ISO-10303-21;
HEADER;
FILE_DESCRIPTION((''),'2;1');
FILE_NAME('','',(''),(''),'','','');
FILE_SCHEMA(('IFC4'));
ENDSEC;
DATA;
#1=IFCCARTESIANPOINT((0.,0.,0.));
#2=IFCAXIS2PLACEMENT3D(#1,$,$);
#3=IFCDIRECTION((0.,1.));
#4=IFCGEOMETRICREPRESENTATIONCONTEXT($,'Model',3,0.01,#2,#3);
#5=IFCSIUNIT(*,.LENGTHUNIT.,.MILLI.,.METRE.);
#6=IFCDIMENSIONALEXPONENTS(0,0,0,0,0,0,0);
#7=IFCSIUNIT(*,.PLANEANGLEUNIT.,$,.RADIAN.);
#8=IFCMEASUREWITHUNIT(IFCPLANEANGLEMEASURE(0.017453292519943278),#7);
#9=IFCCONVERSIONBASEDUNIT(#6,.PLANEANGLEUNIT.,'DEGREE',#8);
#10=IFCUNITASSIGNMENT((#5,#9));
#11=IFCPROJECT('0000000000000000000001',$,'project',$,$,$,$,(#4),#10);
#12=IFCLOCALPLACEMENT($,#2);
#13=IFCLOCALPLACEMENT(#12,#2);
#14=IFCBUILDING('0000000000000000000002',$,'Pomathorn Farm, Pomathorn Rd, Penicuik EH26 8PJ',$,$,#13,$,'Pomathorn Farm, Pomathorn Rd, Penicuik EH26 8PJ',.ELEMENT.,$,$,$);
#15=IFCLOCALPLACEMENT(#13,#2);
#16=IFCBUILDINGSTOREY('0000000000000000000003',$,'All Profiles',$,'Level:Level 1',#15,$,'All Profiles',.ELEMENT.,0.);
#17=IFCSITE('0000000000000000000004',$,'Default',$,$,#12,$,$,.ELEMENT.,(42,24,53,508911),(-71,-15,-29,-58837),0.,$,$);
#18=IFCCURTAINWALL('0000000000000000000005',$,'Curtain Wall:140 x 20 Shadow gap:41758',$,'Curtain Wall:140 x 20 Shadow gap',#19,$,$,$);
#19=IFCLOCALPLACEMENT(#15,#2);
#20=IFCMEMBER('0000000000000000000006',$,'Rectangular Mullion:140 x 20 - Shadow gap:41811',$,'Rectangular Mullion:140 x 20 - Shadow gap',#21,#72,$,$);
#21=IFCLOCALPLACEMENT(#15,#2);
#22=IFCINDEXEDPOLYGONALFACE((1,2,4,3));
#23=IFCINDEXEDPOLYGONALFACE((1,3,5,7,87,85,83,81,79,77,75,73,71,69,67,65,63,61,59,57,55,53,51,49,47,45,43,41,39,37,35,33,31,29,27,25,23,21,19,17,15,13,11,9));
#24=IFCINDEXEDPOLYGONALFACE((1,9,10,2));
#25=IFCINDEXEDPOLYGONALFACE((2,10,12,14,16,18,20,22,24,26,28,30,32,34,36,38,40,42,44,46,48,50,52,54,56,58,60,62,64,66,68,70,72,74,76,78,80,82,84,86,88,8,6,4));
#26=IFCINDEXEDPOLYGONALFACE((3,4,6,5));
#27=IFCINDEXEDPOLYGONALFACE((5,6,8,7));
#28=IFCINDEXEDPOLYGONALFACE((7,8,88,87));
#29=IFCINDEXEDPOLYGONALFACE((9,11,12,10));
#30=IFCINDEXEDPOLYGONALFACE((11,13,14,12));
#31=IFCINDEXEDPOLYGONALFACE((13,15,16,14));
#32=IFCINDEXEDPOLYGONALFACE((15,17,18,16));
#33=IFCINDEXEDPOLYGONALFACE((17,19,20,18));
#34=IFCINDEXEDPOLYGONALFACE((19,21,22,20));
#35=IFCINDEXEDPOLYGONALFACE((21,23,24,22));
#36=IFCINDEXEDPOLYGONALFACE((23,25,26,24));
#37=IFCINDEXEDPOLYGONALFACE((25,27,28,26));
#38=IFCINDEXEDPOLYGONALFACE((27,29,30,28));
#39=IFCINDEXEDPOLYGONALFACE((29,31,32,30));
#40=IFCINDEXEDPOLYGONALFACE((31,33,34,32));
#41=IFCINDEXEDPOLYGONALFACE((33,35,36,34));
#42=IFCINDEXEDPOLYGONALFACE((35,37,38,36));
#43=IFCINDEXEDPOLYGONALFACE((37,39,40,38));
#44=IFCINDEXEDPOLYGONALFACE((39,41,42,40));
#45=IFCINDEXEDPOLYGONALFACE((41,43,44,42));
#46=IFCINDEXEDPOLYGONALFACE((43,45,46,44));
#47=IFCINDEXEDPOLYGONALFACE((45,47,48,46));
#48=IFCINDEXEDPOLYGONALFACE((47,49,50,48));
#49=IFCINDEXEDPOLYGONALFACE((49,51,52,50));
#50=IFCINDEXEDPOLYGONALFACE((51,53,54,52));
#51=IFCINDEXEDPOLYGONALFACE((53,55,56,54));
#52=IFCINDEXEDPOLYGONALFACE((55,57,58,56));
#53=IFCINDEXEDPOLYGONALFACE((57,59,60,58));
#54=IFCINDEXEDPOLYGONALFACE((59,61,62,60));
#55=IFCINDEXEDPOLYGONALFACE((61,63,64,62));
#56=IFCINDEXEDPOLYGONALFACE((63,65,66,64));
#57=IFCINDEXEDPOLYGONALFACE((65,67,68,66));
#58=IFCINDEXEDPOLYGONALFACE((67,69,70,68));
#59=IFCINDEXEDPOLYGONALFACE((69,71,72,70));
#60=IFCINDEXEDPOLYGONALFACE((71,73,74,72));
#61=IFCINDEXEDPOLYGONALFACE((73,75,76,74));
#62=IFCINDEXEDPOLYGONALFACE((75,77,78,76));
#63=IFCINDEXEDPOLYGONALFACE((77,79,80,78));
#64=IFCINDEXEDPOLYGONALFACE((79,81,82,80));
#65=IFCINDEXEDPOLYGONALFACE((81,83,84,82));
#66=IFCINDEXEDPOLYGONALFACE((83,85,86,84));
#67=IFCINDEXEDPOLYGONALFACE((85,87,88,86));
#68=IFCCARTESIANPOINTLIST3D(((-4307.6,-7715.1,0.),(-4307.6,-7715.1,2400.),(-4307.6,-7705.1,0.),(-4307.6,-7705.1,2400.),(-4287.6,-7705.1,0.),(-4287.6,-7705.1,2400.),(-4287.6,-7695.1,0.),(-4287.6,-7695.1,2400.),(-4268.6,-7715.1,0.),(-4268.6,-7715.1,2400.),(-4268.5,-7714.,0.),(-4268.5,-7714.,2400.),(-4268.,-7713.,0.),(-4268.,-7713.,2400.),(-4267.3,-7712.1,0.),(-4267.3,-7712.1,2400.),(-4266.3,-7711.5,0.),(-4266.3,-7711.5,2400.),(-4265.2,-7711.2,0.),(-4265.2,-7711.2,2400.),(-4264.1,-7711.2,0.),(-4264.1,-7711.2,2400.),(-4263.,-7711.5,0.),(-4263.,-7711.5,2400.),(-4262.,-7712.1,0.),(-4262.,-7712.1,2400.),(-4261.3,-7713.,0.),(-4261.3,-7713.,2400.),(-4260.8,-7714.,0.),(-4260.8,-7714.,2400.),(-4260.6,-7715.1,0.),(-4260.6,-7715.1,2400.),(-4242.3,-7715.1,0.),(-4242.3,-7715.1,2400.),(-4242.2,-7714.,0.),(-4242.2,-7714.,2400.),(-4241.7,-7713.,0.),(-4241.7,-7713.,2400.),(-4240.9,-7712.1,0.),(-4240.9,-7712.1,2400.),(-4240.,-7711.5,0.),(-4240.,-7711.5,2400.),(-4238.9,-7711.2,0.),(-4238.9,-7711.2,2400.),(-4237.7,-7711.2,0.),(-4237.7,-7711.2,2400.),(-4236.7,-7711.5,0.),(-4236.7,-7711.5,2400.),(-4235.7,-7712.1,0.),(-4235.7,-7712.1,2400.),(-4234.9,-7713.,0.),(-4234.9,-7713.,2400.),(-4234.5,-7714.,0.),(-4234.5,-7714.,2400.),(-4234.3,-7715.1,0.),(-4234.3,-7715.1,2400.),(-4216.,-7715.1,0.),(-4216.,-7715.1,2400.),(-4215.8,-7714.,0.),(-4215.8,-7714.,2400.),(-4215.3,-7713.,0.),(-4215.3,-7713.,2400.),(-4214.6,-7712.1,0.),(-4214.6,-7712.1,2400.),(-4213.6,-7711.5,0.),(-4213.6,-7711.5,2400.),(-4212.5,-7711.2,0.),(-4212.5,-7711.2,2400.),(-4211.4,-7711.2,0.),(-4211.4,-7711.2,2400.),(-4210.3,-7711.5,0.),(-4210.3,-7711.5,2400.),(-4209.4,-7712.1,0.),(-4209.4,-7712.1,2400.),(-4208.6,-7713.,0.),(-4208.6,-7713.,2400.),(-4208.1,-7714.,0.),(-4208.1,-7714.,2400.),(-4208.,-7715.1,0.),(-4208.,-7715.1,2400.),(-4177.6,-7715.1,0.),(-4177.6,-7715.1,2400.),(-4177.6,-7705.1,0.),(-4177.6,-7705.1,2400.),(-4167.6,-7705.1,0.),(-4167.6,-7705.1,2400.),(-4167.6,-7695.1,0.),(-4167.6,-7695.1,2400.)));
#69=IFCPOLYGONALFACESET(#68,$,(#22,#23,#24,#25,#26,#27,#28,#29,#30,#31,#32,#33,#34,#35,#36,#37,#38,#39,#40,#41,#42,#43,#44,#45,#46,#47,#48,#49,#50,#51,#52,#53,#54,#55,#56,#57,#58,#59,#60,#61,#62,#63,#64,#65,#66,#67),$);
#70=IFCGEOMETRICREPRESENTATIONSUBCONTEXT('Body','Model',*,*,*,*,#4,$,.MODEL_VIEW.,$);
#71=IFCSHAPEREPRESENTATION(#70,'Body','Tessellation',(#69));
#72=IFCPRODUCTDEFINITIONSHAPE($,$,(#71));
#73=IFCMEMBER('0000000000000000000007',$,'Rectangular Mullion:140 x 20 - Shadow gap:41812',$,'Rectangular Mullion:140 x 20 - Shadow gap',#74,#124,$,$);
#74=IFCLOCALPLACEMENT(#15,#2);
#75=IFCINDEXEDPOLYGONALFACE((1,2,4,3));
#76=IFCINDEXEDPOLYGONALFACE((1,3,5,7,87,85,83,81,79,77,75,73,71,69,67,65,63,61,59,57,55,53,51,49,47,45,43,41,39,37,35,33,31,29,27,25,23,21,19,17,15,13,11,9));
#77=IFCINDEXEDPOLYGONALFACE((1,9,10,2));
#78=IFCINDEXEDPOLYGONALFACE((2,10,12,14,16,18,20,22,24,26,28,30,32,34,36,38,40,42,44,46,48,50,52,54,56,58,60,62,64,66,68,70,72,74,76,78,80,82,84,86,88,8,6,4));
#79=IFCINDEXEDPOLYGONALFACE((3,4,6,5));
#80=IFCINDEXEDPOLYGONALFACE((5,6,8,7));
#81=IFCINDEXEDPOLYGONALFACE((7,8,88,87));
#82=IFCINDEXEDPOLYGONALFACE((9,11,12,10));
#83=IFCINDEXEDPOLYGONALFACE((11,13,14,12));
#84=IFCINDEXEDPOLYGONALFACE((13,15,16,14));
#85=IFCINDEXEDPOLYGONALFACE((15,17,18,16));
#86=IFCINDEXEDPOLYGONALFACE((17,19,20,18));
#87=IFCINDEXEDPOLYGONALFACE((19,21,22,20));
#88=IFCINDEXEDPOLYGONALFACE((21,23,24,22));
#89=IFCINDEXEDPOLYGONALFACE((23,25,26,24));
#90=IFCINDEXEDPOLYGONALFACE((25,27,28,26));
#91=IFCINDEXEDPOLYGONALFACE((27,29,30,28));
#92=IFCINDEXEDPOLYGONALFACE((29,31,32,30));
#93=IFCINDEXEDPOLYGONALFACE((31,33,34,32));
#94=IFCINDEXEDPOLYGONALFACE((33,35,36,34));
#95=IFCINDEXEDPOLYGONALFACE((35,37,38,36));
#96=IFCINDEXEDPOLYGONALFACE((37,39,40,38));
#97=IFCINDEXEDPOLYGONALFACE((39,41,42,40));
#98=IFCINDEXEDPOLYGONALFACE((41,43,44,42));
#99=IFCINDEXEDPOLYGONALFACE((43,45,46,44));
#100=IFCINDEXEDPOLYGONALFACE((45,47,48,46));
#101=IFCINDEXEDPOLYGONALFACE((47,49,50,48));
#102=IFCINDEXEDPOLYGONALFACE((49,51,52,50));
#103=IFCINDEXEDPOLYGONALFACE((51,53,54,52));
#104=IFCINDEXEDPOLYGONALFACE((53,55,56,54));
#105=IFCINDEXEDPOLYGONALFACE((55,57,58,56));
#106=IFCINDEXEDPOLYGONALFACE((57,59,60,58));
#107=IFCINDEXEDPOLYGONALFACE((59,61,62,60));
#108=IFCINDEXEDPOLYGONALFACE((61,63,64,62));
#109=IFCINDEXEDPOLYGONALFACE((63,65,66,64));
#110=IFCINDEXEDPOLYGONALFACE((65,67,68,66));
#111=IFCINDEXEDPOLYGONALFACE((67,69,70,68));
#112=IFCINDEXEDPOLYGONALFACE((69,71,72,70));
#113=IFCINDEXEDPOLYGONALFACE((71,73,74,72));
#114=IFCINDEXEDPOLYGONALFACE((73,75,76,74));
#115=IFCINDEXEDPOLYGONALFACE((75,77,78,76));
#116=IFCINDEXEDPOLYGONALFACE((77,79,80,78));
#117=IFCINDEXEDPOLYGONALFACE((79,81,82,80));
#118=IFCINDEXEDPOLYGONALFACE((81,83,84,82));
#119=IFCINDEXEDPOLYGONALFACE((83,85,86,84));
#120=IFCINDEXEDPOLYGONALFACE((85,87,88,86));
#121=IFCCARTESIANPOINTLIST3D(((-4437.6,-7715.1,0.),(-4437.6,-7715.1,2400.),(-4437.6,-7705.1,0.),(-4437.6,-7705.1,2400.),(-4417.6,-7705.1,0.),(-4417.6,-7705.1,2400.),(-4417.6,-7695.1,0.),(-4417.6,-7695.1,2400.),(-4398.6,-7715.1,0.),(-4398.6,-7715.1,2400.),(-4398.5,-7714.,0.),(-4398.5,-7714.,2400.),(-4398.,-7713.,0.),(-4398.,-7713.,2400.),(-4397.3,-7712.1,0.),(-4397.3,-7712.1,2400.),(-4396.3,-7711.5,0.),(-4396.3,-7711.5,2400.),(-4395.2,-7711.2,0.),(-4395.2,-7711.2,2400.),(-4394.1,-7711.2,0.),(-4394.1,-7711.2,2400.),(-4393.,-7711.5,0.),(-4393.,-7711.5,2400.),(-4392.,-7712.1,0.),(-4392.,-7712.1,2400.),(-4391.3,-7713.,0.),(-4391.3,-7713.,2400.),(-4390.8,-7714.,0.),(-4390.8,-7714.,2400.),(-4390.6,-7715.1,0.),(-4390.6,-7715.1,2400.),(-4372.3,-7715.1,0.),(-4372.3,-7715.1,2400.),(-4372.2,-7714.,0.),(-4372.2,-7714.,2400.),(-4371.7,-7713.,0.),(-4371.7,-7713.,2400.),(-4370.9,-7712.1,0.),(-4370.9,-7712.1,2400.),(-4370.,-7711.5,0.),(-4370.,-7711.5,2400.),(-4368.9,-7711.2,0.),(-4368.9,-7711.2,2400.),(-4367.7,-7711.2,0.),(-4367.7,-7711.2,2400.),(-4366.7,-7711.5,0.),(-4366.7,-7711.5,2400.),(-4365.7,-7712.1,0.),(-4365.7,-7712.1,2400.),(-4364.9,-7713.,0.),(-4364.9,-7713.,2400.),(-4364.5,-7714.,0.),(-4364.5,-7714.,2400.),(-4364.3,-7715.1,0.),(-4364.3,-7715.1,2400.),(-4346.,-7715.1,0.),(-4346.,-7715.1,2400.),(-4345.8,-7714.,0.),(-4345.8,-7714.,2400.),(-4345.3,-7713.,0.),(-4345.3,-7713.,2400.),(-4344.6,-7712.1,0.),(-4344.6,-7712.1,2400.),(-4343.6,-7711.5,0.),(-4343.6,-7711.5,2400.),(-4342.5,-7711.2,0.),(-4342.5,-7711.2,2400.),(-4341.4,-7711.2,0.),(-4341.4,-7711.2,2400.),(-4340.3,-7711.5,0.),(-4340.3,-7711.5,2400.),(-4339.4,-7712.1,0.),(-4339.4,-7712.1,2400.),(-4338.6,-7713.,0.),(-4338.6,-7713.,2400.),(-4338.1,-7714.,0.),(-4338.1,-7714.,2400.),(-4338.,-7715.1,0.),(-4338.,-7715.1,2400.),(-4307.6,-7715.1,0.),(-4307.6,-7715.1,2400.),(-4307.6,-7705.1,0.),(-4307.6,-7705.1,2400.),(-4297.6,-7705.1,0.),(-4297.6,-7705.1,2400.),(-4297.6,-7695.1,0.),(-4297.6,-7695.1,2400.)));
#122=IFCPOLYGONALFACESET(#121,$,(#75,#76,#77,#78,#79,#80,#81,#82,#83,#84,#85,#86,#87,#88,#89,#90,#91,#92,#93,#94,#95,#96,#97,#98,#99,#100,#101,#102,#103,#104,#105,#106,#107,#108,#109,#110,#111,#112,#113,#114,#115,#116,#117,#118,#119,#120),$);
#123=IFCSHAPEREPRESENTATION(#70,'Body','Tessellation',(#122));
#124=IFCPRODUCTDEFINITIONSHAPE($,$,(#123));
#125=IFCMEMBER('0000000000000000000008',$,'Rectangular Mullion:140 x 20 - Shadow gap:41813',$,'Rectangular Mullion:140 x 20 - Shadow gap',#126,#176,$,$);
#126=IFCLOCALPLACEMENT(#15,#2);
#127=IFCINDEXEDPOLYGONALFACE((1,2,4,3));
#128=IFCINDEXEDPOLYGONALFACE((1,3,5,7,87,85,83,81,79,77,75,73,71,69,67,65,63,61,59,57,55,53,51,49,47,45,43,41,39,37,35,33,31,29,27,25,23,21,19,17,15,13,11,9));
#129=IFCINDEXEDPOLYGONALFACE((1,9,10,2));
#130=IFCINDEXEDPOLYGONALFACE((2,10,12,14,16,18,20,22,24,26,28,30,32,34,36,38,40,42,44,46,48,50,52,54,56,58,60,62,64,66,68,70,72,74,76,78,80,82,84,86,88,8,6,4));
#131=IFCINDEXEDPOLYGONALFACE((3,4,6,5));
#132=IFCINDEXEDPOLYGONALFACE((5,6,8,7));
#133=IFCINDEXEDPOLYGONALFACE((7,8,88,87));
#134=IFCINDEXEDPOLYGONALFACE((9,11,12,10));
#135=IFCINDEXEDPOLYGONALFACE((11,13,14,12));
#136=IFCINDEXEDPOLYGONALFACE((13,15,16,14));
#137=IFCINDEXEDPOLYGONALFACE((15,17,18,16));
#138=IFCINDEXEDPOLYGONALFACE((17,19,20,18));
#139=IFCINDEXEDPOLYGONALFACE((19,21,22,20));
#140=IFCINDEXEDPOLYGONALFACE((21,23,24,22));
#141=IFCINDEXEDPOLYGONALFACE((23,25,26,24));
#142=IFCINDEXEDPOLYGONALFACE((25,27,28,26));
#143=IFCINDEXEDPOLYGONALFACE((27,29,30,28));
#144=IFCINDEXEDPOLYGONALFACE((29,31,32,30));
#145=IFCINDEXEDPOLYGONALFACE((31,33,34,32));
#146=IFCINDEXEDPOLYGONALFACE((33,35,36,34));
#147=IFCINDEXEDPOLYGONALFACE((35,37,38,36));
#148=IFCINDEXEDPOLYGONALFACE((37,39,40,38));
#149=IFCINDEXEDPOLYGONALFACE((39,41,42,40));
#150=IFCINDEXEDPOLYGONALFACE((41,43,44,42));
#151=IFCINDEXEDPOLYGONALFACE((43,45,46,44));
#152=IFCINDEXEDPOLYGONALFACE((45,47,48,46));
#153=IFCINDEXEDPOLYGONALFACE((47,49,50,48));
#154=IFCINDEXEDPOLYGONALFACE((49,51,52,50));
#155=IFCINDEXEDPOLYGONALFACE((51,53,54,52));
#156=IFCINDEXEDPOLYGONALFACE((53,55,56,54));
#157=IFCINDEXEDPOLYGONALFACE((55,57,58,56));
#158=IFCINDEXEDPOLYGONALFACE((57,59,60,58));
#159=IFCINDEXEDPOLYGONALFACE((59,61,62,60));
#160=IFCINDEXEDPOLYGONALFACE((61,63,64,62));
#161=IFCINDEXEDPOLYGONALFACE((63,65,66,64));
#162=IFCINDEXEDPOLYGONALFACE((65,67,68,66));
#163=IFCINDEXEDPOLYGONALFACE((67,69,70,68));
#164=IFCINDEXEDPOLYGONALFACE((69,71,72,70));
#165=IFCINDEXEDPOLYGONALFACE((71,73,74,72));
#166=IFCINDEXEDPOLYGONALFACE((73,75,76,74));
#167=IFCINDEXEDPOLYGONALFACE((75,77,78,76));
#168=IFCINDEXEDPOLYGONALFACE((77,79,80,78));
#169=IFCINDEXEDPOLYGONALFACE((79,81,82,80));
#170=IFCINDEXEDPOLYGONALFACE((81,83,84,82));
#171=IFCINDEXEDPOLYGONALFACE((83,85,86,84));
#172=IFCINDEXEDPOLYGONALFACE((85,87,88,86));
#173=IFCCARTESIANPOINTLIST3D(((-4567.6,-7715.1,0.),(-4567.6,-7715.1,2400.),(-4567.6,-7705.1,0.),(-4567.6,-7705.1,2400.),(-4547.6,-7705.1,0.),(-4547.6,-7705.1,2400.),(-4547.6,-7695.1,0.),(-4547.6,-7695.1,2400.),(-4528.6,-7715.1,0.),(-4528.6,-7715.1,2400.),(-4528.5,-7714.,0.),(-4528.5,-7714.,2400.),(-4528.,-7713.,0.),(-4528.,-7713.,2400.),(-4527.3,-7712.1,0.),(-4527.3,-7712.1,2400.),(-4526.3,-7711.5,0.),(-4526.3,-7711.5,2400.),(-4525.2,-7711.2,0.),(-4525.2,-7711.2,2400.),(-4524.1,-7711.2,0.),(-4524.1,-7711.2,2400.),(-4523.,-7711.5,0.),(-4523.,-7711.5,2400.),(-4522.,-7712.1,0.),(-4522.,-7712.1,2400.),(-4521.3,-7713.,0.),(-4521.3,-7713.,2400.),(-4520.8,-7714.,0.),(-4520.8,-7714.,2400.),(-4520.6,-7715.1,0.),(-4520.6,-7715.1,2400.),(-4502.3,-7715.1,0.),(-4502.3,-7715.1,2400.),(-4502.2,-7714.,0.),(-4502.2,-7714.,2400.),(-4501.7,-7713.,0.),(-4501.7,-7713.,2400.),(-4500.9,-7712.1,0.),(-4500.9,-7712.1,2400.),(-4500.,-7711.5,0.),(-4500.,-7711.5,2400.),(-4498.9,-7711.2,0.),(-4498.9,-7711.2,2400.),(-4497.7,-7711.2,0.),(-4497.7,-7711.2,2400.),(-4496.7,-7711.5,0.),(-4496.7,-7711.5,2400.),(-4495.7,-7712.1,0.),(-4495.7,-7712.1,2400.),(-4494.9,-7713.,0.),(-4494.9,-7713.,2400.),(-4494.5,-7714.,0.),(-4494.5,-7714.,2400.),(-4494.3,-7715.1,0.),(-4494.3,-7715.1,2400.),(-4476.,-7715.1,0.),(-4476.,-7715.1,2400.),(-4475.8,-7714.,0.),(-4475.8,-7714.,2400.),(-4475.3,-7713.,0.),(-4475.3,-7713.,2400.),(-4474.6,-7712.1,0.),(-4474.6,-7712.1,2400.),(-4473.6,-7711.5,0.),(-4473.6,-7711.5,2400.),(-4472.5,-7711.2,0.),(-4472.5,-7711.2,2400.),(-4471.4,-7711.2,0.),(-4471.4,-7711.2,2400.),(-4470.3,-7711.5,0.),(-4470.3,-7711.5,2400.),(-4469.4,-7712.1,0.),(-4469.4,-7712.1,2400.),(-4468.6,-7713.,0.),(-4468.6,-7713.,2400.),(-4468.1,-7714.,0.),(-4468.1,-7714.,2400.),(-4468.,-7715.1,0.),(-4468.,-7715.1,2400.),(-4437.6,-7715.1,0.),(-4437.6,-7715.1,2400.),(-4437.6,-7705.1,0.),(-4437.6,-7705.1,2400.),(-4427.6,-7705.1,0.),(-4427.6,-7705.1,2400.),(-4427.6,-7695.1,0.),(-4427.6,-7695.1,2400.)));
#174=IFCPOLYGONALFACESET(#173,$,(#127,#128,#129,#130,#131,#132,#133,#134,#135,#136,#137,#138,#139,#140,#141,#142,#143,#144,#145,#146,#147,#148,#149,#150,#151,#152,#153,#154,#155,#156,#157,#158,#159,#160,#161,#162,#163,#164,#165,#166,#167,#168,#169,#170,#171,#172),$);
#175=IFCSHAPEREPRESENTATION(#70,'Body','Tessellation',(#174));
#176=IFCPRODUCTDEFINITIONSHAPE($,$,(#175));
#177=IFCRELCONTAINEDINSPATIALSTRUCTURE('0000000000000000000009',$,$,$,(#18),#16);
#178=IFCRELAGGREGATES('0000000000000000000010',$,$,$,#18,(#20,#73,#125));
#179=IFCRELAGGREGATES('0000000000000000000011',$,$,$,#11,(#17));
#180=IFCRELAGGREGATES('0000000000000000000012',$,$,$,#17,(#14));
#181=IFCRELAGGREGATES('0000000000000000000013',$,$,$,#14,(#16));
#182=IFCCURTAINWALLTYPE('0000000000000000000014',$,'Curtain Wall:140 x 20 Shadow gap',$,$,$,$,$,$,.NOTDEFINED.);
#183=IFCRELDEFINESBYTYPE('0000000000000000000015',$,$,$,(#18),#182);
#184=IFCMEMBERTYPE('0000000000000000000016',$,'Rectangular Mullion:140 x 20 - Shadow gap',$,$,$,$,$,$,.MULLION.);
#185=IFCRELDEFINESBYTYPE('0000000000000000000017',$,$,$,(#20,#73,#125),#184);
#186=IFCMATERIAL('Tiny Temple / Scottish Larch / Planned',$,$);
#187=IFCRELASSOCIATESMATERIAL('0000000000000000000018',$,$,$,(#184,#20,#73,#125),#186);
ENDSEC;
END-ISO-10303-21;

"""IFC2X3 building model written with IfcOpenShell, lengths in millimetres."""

from ifc_helpers import new_model, entity, si_unit, converted_unit, direction, frame, frame_2d, origin, place, context, subcontext, project, spatial, polyline, circle_curve, parameter, trimmed, segment, composite_curve, outline, extrude, source, transform, mapped, material, type_object, type_shapes, element, aggregate, save


model = new_model("IFC2X3")

# Units and contexts
model_context = context("Model", 3, precision=0.01, world=origin(), true_north=direction((0.0, 1.0)))
body_context = subcontext(model_context, "Body", "Model", "MODEL_VIEW")
ifc_project = project(units=[si_unit("LENGTHUNIT", "METRE", prefix="MILLI"), converted_unit("PLANEANGLEUNIT", "DEGREE", entity("IfcPlaneAngleMeasure", 0.017453292519943278), si_unit("PLANEANGLEUNIT", "RADIAN"), dimensions=[0, 0, 0, 0, 0, 0, 0])], contexts=[model_context])

# Site, building, storey
site_placement = place(None, origin())
site = spatial("IfcSite", under=ifc_project, at=site_placement, Name="Default", CompositionType="ELEMENT", RefLatitude=(42, 24, 53, 508911), RefLongitude=(-71, -15, -29, -58837), RefElevation=0.0)
building_placement = place(site_placement, origin())
building = spatial("IfcBuilding", under=site, at=building_placement, Name="Pomathorn Farm, Pomathorn Rd, Penicuik EH26 8PJ", LongName="Pomathorn Farm, Pomathorn Rd, Penicuik EH26 8PJ", CompositionType="ELEMENT")
storey_placement = place(building_placement, origin())
storey = spatial("IfcBuildingStorey", under=building, at=storey_placement, Name="All Profiles", ObjectType="Level:Level 1", LongName="All Profiles", CompositionType="ELEMENT", Elevation=0.0)

# Curtain wall, members
ifc_material = material(Name="Tiny Temple / Scottish Larch / Planned")
curtain_wall_type_1 = type_object("IfcCurtainWallType", Name="Curtain Wall:140 x 20 Shadow gap", PredefinedType="NOTDEFINED")
curtain_wall_1_placement = place(storey_placement, origin())
curtain_wall_1 = element("IfcCurtainWall", 1, at=curtain_wall_1_placement, inside=storey, type_object=curtain_wall_type_1, Name="Curtain Wall:140 x 20 Shadow gap:41758", ObjectType="Curtain Wall:140 x 20 Shadow gap")
member_type_1 = type_object("IfcMemberType", Name="Rectangular Mullion:140 x 20 - Shadow gap", PredefinedType="MULLION", material=ifc_material)
shared_shape_1 = source(origin(), body_context, "Body", "SweptSolid", [
    extrude(outline(composite_curve([segment(polyline([(28.5, -5.7), (58.9, -5.7)]), True, "CONTINUOUS"), segment(polyline([(58.9, -5.7), (58.9, 4.3)]), True, "CONTINUOUS"), segment(polyline([(58.9, 4.3), (68.9, 4.3)]), True, "CONTINUOUS"), segment(polyline([(68.9, 4.3), (68.9, 14.3)]), True, "CONTINUOUS"), segment(polyline([(68.9, 14.3), (-51.1, 14.3)]), True, "CONTINUOUS"), segment(polyline([(-51.1, 14.3), (-51.1, 4.3)]), True, "CONTINUOUS"), segment(polyline([(-51.1, 4.3), (-71.1, 4.3)]), True, "CONTINUOUS"), segment(polyline([(-71.1, 4.3), (-71.1, -5.7)]), True, "CONTINUOUS"), segment(polyline([(-71.1, -5.7), (-32.1, -5.7)]), True, "CONTINUOUS"), segment(trimmed(circle_curve(frame_2d((-28.1, -5.7), x_axis=(1.0, 0.0)), 4.0), [parameter(360.0)], [parameter(180.0)], True, "PARAMETER"), False, "CONTINUOUS"), segment(polyline([(-24.1, -5.7), (-5.8, -5.7)]), True, "CONTINUOUS"), segment(trimmed(circle_curve(frame_2d((-1.8, -5.7), x_axis=(1.0, 0.0)), 4.0), [parameter(360.0)], [parameter(180.0)], True, "PARAMETER"), False, "CONTINUOUS"), segment(polyline([(2.2, -5.7), (20.5, -5.7)]), True, "CONTINUOUS"), segment(trimmed(circle_curve(frame_2d((24.5, -5.7), x_axis=(1.0, 0.0)), 4.0), [parameter(360.0)], [parameter(180.0)], True, "PARAMETER"), False, "CONTINUOUS")], self_intersect=False)), frame((-68.9, -5.7, -2400.0), z_axis=(0.0, 0.0, -1.0), x_axis=(1.0, 0.0, 0.0)), (0.0, 0.0, -1.0), 2400.0),
])
type_shapes(member_type_1, [shared_shape_1])
member_1_placement = place(curtain_wall_1_placement, frame((-4167.6, -7715.1, 0.0), z_axis=(0.0, 0.0, -1.0), x_axis=(1.0, 0.0, 0.0)))
member_1 = element("IfcMember", 2, at=member_1_placement, type_object=member_type_1, material=ifc_material, Name="Rectangular Mullion:140 x 20 - Shadow gap:41811", ObjectType="Rectangular Mullion:140 x 20 - Shadow gap", context=body_context, shape_type="MappedRepresentation", body=[
    mapped(shared_shape_1, transform((0.0, 0.0, 0.0), scale=1.0)),
])
member_2_placement = place(curtain_wall_1_placement, frame((-4297.6, -7715.1, 0.0), z_axis=(0.0, 0.0, -1.0), x_axis=(1.0, 0.0, 0.0)))
member_2 = element("IfcMember", 3, at=member_2_placement, type_object=member_type_1, material=ifc_material, Name="Rectangular Mullion:140 x 20 - Shadow gap:41812", ObjectType="Rectangular Mullion:140 x 20 - Shadow gap", context=body_context, shape_type="MappedRepresentation", body=[
    mapped(shared_shape_1, transform((0.0, 0.0, 0.0), scale=1.0)),
])
member_3_placement = place(curtain_wall_1_placement, frame((-4427.6, -7715.1, 0.0), z_axis=(0.0, 0.0, -1.0), x_axis=(1.0, 0.0, 0.0)))
member_3 = element("IfcMember", 4, at=member_3_placement, type_object=member_type_1, material=ifc_material, Name="Rectangular Mullion:140 x 20 - Shadow gap:41813", ObjectType="Rectangular Mullion:140 x 20 - Shadow gap", context=body_context, shape_type="MappedRepresentation", body=[
    mapped(shared_shape_1, transform((0.0, 0.0, 0.0), scale=1.0)),
])
aggregate(curtain_wall_1, [member_1, member_2, member_3])

save(model, "model.ifc")
